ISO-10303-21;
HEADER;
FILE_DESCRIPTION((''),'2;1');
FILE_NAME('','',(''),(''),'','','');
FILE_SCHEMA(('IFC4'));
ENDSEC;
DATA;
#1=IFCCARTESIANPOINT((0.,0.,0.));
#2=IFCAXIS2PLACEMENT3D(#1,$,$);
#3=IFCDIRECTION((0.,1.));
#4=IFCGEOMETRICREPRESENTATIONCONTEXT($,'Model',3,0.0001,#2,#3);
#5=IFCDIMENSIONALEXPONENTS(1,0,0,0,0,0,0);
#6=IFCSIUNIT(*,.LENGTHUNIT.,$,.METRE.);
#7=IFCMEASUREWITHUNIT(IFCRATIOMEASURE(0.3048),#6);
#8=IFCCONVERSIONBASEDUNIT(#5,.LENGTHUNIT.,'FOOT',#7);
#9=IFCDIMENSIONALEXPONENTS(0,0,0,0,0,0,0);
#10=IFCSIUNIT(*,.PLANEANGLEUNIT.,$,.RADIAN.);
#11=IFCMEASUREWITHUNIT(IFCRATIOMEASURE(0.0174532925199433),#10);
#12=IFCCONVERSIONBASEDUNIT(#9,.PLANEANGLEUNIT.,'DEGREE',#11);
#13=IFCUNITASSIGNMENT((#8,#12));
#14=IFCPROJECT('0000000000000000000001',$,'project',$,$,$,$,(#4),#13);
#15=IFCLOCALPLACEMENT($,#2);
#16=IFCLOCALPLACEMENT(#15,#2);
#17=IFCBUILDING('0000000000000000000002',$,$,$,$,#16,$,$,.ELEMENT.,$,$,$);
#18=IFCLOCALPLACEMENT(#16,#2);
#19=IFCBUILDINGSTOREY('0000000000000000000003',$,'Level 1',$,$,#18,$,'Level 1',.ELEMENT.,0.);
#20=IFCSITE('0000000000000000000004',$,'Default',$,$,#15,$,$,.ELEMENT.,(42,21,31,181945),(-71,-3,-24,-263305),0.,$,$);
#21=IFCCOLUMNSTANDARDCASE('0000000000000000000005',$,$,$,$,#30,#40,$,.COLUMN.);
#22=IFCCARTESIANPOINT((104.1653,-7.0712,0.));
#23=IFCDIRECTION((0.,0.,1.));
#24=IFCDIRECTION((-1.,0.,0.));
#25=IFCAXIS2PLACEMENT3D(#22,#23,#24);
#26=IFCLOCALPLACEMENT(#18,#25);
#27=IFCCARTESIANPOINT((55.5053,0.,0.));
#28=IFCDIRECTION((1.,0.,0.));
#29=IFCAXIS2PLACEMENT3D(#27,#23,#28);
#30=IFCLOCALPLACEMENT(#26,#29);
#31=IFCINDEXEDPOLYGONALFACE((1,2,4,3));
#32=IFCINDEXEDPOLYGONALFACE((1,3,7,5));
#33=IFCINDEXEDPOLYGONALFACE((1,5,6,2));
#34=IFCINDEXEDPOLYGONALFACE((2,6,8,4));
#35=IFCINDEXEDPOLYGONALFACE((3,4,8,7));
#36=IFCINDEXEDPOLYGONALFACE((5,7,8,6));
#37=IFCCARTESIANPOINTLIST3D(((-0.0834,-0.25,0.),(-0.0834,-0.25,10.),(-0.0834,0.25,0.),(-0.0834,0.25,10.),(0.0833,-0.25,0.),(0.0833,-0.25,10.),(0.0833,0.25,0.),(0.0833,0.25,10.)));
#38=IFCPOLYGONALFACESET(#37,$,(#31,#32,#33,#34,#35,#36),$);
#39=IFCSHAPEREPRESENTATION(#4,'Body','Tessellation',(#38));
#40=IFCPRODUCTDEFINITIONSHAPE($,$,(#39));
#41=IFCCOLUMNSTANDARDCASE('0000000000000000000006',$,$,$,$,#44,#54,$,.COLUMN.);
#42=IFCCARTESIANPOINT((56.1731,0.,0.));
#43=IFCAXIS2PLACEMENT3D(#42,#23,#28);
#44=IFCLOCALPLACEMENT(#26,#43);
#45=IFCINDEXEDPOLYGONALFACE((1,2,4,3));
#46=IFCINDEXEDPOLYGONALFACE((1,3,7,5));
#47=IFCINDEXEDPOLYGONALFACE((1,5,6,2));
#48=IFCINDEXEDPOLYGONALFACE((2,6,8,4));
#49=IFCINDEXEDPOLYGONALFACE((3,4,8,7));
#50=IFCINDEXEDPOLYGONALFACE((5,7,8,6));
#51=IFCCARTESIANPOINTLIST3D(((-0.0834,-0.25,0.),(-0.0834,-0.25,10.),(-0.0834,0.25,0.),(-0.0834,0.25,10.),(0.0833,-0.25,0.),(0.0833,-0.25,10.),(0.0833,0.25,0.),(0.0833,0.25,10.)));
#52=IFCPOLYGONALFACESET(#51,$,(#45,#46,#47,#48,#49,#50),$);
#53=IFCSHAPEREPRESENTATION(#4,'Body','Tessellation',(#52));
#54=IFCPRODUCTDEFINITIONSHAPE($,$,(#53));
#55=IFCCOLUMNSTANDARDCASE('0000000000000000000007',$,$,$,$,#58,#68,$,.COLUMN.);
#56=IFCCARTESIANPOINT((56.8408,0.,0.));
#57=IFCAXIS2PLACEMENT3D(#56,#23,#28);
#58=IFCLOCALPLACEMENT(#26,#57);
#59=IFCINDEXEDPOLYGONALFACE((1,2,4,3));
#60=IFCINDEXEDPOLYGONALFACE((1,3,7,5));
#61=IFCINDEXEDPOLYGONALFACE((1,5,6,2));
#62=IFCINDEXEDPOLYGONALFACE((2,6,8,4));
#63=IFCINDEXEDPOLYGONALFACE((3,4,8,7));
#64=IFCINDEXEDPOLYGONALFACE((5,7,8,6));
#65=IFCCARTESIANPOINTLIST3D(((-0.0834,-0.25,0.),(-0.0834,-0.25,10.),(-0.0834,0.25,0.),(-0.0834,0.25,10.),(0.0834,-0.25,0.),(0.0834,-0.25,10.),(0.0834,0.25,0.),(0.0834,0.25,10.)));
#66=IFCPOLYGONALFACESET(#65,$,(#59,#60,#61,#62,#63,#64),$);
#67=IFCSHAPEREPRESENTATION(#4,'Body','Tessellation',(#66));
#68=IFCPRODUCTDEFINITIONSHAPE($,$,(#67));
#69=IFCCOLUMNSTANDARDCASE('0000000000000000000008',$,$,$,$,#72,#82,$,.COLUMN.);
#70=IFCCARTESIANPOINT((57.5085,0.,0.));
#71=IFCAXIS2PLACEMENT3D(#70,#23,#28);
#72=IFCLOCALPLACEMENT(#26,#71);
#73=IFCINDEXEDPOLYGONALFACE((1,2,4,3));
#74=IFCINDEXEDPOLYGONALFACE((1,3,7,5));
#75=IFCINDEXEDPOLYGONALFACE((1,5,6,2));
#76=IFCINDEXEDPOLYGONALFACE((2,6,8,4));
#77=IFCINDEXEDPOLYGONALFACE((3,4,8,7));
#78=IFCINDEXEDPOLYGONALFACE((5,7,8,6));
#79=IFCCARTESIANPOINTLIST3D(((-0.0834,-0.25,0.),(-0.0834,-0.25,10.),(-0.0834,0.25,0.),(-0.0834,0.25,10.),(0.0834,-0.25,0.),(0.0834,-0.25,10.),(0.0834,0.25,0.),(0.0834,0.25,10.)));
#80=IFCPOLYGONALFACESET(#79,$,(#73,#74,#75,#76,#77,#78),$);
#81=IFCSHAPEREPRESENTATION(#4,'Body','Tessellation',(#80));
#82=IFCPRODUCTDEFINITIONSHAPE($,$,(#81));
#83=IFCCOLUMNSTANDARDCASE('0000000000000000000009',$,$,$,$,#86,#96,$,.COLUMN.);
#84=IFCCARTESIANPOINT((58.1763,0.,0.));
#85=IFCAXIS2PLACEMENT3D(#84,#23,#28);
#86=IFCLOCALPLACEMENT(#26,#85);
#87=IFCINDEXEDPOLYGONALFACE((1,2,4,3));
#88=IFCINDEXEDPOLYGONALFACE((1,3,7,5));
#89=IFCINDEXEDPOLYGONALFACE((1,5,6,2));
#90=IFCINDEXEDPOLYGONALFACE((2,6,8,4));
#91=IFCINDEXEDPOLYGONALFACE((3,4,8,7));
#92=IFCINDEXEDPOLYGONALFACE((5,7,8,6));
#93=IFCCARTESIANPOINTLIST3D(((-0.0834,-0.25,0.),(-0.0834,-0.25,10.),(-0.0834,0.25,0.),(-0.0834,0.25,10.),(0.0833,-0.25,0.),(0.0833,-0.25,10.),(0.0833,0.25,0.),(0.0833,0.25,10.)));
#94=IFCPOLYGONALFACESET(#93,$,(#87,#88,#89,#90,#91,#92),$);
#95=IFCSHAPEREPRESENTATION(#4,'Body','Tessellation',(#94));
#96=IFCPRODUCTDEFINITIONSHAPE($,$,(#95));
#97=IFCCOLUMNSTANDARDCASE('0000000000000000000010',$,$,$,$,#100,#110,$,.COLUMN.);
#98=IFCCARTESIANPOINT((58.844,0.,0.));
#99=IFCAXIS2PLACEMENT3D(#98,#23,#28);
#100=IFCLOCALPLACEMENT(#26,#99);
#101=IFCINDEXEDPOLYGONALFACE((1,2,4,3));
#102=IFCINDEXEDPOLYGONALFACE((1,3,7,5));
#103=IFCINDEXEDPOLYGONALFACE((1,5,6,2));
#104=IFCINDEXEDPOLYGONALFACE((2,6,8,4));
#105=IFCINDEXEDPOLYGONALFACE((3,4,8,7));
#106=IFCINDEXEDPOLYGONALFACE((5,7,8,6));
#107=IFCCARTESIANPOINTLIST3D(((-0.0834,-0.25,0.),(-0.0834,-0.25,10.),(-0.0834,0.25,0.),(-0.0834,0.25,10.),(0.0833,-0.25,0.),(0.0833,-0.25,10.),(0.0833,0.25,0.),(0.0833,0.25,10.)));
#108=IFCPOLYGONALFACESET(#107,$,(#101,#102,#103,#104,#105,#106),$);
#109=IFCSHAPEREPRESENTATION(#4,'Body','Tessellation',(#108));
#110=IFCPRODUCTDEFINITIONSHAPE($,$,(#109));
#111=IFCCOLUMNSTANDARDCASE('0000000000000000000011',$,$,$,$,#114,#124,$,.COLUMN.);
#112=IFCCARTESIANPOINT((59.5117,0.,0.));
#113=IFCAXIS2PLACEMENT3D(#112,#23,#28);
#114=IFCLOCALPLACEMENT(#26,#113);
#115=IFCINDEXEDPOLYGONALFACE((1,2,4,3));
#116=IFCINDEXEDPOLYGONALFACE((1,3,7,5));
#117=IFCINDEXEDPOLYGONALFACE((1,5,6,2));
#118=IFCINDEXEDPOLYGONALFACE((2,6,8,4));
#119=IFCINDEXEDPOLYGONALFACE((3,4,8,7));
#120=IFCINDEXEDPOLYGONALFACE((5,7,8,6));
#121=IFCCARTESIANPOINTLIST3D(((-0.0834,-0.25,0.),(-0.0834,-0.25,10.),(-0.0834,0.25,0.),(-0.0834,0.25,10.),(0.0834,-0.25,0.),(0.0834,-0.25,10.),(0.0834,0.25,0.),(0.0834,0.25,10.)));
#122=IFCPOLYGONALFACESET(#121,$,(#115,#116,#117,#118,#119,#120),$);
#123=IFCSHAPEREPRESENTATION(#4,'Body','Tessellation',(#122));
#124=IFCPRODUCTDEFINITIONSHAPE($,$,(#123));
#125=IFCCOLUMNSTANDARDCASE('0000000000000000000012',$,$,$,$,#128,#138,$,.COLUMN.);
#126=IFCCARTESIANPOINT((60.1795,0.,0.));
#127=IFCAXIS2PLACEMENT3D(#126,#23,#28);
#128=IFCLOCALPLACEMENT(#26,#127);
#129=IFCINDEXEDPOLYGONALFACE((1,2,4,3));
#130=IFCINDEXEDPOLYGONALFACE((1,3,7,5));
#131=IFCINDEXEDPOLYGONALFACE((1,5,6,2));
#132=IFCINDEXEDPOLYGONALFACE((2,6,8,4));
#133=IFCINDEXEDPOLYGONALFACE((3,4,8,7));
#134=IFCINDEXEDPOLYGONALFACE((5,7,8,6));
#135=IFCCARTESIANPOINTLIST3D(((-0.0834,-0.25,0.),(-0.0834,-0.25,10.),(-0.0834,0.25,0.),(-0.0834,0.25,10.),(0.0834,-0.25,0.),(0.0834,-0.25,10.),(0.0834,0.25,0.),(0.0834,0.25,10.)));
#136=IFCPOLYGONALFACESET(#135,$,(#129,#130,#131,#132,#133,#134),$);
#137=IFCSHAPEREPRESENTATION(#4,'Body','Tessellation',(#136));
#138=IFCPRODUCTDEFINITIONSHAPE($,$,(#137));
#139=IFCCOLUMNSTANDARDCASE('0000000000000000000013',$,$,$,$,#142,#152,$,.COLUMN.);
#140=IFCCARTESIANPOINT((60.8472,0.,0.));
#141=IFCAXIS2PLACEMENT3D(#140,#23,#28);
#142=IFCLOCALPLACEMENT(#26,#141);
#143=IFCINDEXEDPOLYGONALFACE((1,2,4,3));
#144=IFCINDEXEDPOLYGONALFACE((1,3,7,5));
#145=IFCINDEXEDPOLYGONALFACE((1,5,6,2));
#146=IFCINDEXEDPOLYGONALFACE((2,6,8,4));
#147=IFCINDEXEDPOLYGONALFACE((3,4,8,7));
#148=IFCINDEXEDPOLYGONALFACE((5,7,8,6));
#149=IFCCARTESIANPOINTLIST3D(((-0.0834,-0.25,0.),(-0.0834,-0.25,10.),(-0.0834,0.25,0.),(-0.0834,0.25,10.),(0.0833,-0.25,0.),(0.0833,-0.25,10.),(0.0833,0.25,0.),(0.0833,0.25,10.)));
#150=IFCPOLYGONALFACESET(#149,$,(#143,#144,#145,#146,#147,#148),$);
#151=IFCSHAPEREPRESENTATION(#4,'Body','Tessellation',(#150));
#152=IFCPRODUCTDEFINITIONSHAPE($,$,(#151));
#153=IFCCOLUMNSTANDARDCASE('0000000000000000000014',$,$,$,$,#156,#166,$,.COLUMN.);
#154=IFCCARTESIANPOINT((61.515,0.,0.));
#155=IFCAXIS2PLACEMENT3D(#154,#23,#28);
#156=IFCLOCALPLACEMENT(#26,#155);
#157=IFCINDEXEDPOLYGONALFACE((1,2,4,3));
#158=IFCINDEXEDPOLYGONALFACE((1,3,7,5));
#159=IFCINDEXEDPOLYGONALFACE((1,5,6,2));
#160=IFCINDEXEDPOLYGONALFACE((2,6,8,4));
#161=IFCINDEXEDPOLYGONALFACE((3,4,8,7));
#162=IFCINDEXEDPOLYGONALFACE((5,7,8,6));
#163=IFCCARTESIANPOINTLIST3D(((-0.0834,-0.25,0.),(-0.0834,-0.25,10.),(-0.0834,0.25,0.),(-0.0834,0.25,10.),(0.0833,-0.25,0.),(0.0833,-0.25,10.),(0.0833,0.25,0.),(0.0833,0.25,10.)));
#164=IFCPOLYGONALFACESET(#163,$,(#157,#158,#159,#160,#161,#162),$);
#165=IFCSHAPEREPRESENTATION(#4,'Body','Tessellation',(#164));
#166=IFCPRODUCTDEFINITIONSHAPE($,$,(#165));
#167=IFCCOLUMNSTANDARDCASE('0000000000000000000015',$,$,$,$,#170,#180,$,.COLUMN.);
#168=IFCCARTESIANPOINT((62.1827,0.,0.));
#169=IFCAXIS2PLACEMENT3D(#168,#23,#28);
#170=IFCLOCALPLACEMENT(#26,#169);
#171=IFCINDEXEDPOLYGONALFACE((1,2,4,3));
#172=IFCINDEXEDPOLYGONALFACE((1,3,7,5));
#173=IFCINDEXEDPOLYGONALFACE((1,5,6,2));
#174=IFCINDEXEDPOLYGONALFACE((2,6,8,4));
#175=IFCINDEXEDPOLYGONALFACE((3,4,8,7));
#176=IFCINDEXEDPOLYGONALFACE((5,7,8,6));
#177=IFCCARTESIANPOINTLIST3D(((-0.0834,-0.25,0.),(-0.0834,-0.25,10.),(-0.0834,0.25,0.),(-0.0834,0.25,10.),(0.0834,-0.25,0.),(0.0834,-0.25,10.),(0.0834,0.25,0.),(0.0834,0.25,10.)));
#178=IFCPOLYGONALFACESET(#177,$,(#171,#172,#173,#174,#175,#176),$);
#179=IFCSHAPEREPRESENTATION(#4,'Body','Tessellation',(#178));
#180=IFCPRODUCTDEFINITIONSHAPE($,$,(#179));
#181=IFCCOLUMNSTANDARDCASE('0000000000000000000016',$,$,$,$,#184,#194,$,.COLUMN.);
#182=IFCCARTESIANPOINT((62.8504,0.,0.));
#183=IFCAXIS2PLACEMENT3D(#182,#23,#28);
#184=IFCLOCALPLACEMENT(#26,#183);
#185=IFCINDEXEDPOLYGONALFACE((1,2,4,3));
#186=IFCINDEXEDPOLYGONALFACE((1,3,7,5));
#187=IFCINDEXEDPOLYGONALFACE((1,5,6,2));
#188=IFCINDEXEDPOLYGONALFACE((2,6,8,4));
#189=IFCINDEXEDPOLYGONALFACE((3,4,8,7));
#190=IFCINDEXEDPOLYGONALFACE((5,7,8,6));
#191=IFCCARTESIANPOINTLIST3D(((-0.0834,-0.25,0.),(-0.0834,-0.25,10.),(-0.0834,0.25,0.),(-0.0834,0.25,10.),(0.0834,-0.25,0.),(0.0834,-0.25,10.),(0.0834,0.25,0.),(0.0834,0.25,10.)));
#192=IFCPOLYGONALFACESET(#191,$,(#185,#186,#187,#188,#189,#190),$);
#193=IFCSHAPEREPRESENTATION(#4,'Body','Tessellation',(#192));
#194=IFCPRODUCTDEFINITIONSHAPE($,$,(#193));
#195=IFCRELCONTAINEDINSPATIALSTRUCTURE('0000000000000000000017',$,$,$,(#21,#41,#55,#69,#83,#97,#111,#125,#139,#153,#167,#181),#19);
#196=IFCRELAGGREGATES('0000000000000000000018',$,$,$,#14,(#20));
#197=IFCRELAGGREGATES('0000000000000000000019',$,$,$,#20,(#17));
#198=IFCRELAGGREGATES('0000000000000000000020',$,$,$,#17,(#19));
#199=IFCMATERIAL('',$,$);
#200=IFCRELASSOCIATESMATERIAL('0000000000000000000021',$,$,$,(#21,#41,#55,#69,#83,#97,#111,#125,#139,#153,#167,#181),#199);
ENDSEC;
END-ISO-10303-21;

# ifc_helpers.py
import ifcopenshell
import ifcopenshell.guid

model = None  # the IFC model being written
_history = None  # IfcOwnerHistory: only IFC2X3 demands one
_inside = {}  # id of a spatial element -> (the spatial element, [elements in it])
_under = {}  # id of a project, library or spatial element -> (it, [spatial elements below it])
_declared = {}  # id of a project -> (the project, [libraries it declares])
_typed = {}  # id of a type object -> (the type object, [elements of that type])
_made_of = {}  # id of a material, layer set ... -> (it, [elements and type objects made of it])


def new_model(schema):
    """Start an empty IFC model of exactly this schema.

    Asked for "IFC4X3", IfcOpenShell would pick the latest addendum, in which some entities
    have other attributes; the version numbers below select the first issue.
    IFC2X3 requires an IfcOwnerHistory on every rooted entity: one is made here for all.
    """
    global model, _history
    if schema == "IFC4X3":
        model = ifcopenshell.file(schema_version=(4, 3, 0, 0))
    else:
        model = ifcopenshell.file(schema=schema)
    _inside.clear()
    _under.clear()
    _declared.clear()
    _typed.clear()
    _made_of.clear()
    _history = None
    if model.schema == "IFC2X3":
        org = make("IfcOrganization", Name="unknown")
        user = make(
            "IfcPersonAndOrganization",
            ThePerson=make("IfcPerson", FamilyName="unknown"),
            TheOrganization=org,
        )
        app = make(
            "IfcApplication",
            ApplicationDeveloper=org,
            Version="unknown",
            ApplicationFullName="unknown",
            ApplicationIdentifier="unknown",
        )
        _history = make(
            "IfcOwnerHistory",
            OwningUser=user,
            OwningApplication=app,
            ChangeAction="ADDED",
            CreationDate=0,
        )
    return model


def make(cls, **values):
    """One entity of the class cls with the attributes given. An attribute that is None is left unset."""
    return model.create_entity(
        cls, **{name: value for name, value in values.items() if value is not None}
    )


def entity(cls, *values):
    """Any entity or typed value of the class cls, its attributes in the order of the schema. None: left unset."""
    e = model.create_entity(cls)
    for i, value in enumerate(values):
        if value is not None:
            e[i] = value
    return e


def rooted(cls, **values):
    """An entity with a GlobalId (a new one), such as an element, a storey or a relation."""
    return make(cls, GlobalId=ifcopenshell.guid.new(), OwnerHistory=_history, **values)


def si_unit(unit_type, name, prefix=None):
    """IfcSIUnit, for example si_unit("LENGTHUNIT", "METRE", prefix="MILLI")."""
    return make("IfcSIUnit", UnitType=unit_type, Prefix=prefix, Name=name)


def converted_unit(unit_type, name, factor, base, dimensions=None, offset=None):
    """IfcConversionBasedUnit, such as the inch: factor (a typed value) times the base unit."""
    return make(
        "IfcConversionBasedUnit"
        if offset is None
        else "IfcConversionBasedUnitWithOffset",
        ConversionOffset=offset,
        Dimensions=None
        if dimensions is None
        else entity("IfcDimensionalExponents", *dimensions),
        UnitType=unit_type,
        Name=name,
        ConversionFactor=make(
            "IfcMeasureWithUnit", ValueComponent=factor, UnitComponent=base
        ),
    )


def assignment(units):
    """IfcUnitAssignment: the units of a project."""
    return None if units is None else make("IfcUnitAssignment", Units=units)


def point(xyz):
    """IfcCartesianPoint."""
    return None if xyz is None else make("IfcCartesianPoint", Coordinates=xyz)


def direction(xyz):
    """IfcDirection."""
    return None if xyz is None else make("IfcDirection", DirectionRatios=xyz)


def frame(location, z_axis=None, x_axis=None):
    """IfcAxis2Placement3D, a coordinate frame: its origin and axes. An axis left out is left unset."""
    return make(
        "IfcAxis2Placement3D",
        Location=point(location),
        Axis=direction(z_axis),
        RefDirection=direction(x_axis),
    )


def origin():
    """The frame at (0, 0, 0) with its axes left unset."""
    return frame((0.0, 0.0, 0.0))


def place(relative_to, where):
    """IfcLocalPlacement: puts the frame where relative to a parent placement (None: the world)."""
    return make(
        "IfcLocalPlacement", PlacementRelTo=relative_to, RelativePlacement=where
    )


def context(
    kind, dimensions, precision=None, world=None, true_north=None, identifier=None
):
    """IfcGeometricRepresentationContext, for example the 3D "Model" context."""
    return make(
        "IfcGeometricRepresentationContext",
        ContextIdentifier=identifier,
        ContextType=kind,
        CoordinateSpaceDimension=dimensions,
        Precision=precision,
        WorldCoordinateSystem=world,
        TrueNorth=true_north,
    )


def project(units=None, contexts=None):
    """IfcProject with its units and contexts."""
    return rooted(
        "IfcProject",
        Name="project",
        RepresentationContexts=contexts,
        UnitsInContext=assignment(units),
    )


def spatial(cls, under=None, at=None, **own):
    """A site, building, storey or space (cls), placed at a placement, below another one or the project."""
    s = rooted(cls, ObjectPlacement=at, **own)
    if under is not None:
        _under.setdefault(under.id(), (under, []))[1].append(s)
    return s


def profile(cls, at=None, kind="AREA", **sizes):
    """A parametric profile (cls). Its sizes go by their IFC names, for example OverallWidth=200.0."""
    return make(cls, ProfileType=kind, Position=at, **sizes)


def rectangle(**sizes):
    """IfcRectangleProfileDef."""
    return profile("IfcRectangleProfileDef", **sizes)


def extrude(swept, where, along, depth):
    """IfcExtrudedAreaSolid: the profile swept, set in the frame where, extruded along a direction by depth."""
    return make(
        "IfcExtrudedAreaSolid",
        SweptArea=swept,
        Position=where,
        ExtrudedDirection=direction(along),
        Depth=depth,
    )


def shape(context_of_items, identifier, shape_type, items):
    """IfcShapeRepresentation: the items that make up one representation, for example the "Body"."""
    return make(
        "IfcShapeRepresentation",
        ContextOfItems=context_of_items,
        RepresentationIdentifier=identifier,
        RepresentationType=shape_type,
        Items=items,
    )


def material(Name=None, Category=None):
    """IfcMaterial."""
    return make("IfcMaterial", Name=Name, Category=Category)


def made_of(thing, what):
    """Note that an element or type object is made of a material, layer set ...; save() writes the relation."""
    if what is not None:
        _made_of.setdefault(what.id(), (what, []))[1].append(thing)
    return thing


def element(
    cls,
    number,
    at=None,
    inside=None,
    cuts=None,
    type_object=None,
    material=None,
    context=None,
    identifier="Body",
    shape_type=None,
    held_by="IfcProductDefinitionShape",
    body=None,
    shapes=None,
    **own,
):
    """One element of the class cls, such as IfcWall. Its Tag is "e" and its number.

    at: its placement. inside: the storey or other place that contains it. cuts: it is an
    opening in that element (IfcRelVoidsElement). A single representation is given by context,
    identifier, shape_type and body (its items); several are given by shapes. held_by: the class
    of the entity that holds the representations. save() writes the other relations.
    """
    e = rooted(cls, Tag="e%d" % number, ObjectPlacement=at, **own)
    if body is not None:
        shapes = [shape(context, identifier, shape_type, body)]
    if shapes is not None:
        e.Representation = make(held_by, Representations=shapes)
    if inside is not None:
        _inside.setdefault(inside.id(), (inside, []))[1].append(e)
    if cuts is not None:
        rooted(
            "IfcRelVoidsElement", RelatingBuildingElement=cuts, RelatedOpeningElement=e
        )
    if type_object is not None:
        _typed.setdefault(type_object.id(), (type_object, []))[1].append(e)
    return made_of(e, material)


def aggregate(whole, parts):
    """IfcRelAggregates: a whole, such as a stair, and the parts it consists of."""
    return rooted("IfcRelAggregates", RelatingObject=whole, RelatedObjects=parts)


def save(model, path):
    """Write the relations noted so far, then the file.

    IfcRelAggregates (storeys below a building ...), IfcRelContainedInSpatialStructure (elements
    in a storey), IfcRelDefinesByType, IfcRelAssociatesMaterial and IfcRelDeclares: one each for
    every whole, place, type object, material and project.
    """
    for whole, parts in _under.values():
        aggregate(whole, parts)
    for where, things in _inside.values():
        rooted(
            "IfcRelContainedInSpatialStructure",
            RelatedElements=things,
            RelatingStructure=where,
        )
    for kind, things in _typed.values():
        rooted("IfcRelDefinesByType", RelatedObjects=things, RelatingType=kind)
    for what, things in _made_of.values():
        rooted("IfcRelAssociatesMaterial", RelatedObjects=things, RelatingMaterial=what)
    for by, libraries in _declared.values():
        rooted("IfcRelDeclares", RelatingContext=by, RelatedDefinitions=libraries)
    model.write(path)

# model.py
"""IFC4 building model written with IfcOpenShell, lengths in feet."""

from ifc_helpers import new_model, entity, si_unit, converted_unit, direction, frame, origin, place, context, project, spatial, rectangle, extrude, material, element, save


model = new_model("IFC4")

# Units and contexts
model_context = context("Model", 3, precision=0.0001, world=origin(), true_north=direction((0.0, 1.0)))
ifc_project = project(units=[converted_unit("LENGTHUNIT", "FOOT", entity("IfcRatioMeasure", 0.3048), si_unit("LENGTHUNIT", "METRE"), dimensions=[1, 0, 0, 0, 0, 0, 0]), converted_unit("PLANEANGLEUNIT", "DEGREE", entity("IfcRatioMeasure", 0.0174532925199433), si_unit("PLANEANGLEUNIT", "RADIAN"), dimensions=[0, 0, 0, 0, 0, 0, 0])], contexts=[model_context])

# Site, building, storey
site_placement = place(None, origin())
site = spatial("IfcSite", under=ifc_project, at=site_placement, Name="Default", CompositionType="ELEMENT", RefLatitude=(42, 21, 31, 181945), RefLongitude=(-71, -3, -24, -263305), RefElevation=0.0)
building_placement = place(site_placement, origin())
building = spatial("IfcBuilding", under=site, at=building_placement, CompositionType="ELEMENT")
storey_placement = place(building_placement, origin())
storey = spatial("IfcBuildingStorey", under=building, at=storey_placement, Name="Level 1", LongName="Level 1", CompositionType="ELEMENT", Elevation=0.0)

# Columns
ifc_material = material(Name="")
placement = place(storey_placement, frame((104.1653, -7.0712, 0.0), z_axis=(0.0, 0.0, 1.0), x_axis=(-1.0, 0.0, 0.0)))
for number, where, z_axis, x_axis in (
    (1, (55.5053, 0.0, 0.0), (0.0, 0.0, 1.0), (1.0, 0.0, 0.0)),
    (2, (56.1731, 0.0, 0.0), (0.0, 0.0, 1.0), (1.0, 0.0, 0.0)),
    (3, (56.8408, 0.0, 0.0), (0.0, 0.0, 1.0), (1.0, 0.0, 0.0)),
    (4, (57.5085, 0.0, 0.0), (0.0, 0.0, 1.0), (1.0, 0.0, 0.0)),
    (5, (58.1763, 0.0, 0.0), (0.0, 0.0, 1.0), (1.0, 0.0, 0.0)),
    (6, (58.844, 0.0, 0.0), (0.0, 0.0, 1.0), (1.0, 0.0, 0.0)),
    (7, (59.5117, 0.0, 0.0), (0.0, 0.0, 1.0), (1.0, 0.0, 0.0)),
    (8, (60.1795, 0.0, 0.0), (0.0, 0.0, 1.0), (1.0, 0.0, 0.0)),
    (9, (60.8472, 0.0, 0.0), (0.0, 0.0, 1.0), (1.0, 0.0, 0.0)),
    (10, (61.515, 0.0, 0.0), (0.0, 0.0, 1.0), (1.0, 0.0, 0.0)),
    (11, (62.1827, 0.0, 0.0), (0.0, 0.0, 1.0), (1.0, 0.0, 0.0)),
    (12, (62.8504, 0.0, 0.0), (0.0, 0.0, 1.0), (1.0, 0.0, 0.0)),
):
    element("IfcColumnStandardCase", number, at=place(placement, frame(where, z_axis=z_axis, x_axis=x_axis)), inside=storey, material=ifc_material, PredefinedType="COLUMN", context=model_context, shape_type="SweptSolid", body=[
        extrude(rectangle(XDim=0.1667, YDim=0.5), origin(), (0.0, 0.0, 1.0), 10.0),
    ])

save(model, "model.ifc")
